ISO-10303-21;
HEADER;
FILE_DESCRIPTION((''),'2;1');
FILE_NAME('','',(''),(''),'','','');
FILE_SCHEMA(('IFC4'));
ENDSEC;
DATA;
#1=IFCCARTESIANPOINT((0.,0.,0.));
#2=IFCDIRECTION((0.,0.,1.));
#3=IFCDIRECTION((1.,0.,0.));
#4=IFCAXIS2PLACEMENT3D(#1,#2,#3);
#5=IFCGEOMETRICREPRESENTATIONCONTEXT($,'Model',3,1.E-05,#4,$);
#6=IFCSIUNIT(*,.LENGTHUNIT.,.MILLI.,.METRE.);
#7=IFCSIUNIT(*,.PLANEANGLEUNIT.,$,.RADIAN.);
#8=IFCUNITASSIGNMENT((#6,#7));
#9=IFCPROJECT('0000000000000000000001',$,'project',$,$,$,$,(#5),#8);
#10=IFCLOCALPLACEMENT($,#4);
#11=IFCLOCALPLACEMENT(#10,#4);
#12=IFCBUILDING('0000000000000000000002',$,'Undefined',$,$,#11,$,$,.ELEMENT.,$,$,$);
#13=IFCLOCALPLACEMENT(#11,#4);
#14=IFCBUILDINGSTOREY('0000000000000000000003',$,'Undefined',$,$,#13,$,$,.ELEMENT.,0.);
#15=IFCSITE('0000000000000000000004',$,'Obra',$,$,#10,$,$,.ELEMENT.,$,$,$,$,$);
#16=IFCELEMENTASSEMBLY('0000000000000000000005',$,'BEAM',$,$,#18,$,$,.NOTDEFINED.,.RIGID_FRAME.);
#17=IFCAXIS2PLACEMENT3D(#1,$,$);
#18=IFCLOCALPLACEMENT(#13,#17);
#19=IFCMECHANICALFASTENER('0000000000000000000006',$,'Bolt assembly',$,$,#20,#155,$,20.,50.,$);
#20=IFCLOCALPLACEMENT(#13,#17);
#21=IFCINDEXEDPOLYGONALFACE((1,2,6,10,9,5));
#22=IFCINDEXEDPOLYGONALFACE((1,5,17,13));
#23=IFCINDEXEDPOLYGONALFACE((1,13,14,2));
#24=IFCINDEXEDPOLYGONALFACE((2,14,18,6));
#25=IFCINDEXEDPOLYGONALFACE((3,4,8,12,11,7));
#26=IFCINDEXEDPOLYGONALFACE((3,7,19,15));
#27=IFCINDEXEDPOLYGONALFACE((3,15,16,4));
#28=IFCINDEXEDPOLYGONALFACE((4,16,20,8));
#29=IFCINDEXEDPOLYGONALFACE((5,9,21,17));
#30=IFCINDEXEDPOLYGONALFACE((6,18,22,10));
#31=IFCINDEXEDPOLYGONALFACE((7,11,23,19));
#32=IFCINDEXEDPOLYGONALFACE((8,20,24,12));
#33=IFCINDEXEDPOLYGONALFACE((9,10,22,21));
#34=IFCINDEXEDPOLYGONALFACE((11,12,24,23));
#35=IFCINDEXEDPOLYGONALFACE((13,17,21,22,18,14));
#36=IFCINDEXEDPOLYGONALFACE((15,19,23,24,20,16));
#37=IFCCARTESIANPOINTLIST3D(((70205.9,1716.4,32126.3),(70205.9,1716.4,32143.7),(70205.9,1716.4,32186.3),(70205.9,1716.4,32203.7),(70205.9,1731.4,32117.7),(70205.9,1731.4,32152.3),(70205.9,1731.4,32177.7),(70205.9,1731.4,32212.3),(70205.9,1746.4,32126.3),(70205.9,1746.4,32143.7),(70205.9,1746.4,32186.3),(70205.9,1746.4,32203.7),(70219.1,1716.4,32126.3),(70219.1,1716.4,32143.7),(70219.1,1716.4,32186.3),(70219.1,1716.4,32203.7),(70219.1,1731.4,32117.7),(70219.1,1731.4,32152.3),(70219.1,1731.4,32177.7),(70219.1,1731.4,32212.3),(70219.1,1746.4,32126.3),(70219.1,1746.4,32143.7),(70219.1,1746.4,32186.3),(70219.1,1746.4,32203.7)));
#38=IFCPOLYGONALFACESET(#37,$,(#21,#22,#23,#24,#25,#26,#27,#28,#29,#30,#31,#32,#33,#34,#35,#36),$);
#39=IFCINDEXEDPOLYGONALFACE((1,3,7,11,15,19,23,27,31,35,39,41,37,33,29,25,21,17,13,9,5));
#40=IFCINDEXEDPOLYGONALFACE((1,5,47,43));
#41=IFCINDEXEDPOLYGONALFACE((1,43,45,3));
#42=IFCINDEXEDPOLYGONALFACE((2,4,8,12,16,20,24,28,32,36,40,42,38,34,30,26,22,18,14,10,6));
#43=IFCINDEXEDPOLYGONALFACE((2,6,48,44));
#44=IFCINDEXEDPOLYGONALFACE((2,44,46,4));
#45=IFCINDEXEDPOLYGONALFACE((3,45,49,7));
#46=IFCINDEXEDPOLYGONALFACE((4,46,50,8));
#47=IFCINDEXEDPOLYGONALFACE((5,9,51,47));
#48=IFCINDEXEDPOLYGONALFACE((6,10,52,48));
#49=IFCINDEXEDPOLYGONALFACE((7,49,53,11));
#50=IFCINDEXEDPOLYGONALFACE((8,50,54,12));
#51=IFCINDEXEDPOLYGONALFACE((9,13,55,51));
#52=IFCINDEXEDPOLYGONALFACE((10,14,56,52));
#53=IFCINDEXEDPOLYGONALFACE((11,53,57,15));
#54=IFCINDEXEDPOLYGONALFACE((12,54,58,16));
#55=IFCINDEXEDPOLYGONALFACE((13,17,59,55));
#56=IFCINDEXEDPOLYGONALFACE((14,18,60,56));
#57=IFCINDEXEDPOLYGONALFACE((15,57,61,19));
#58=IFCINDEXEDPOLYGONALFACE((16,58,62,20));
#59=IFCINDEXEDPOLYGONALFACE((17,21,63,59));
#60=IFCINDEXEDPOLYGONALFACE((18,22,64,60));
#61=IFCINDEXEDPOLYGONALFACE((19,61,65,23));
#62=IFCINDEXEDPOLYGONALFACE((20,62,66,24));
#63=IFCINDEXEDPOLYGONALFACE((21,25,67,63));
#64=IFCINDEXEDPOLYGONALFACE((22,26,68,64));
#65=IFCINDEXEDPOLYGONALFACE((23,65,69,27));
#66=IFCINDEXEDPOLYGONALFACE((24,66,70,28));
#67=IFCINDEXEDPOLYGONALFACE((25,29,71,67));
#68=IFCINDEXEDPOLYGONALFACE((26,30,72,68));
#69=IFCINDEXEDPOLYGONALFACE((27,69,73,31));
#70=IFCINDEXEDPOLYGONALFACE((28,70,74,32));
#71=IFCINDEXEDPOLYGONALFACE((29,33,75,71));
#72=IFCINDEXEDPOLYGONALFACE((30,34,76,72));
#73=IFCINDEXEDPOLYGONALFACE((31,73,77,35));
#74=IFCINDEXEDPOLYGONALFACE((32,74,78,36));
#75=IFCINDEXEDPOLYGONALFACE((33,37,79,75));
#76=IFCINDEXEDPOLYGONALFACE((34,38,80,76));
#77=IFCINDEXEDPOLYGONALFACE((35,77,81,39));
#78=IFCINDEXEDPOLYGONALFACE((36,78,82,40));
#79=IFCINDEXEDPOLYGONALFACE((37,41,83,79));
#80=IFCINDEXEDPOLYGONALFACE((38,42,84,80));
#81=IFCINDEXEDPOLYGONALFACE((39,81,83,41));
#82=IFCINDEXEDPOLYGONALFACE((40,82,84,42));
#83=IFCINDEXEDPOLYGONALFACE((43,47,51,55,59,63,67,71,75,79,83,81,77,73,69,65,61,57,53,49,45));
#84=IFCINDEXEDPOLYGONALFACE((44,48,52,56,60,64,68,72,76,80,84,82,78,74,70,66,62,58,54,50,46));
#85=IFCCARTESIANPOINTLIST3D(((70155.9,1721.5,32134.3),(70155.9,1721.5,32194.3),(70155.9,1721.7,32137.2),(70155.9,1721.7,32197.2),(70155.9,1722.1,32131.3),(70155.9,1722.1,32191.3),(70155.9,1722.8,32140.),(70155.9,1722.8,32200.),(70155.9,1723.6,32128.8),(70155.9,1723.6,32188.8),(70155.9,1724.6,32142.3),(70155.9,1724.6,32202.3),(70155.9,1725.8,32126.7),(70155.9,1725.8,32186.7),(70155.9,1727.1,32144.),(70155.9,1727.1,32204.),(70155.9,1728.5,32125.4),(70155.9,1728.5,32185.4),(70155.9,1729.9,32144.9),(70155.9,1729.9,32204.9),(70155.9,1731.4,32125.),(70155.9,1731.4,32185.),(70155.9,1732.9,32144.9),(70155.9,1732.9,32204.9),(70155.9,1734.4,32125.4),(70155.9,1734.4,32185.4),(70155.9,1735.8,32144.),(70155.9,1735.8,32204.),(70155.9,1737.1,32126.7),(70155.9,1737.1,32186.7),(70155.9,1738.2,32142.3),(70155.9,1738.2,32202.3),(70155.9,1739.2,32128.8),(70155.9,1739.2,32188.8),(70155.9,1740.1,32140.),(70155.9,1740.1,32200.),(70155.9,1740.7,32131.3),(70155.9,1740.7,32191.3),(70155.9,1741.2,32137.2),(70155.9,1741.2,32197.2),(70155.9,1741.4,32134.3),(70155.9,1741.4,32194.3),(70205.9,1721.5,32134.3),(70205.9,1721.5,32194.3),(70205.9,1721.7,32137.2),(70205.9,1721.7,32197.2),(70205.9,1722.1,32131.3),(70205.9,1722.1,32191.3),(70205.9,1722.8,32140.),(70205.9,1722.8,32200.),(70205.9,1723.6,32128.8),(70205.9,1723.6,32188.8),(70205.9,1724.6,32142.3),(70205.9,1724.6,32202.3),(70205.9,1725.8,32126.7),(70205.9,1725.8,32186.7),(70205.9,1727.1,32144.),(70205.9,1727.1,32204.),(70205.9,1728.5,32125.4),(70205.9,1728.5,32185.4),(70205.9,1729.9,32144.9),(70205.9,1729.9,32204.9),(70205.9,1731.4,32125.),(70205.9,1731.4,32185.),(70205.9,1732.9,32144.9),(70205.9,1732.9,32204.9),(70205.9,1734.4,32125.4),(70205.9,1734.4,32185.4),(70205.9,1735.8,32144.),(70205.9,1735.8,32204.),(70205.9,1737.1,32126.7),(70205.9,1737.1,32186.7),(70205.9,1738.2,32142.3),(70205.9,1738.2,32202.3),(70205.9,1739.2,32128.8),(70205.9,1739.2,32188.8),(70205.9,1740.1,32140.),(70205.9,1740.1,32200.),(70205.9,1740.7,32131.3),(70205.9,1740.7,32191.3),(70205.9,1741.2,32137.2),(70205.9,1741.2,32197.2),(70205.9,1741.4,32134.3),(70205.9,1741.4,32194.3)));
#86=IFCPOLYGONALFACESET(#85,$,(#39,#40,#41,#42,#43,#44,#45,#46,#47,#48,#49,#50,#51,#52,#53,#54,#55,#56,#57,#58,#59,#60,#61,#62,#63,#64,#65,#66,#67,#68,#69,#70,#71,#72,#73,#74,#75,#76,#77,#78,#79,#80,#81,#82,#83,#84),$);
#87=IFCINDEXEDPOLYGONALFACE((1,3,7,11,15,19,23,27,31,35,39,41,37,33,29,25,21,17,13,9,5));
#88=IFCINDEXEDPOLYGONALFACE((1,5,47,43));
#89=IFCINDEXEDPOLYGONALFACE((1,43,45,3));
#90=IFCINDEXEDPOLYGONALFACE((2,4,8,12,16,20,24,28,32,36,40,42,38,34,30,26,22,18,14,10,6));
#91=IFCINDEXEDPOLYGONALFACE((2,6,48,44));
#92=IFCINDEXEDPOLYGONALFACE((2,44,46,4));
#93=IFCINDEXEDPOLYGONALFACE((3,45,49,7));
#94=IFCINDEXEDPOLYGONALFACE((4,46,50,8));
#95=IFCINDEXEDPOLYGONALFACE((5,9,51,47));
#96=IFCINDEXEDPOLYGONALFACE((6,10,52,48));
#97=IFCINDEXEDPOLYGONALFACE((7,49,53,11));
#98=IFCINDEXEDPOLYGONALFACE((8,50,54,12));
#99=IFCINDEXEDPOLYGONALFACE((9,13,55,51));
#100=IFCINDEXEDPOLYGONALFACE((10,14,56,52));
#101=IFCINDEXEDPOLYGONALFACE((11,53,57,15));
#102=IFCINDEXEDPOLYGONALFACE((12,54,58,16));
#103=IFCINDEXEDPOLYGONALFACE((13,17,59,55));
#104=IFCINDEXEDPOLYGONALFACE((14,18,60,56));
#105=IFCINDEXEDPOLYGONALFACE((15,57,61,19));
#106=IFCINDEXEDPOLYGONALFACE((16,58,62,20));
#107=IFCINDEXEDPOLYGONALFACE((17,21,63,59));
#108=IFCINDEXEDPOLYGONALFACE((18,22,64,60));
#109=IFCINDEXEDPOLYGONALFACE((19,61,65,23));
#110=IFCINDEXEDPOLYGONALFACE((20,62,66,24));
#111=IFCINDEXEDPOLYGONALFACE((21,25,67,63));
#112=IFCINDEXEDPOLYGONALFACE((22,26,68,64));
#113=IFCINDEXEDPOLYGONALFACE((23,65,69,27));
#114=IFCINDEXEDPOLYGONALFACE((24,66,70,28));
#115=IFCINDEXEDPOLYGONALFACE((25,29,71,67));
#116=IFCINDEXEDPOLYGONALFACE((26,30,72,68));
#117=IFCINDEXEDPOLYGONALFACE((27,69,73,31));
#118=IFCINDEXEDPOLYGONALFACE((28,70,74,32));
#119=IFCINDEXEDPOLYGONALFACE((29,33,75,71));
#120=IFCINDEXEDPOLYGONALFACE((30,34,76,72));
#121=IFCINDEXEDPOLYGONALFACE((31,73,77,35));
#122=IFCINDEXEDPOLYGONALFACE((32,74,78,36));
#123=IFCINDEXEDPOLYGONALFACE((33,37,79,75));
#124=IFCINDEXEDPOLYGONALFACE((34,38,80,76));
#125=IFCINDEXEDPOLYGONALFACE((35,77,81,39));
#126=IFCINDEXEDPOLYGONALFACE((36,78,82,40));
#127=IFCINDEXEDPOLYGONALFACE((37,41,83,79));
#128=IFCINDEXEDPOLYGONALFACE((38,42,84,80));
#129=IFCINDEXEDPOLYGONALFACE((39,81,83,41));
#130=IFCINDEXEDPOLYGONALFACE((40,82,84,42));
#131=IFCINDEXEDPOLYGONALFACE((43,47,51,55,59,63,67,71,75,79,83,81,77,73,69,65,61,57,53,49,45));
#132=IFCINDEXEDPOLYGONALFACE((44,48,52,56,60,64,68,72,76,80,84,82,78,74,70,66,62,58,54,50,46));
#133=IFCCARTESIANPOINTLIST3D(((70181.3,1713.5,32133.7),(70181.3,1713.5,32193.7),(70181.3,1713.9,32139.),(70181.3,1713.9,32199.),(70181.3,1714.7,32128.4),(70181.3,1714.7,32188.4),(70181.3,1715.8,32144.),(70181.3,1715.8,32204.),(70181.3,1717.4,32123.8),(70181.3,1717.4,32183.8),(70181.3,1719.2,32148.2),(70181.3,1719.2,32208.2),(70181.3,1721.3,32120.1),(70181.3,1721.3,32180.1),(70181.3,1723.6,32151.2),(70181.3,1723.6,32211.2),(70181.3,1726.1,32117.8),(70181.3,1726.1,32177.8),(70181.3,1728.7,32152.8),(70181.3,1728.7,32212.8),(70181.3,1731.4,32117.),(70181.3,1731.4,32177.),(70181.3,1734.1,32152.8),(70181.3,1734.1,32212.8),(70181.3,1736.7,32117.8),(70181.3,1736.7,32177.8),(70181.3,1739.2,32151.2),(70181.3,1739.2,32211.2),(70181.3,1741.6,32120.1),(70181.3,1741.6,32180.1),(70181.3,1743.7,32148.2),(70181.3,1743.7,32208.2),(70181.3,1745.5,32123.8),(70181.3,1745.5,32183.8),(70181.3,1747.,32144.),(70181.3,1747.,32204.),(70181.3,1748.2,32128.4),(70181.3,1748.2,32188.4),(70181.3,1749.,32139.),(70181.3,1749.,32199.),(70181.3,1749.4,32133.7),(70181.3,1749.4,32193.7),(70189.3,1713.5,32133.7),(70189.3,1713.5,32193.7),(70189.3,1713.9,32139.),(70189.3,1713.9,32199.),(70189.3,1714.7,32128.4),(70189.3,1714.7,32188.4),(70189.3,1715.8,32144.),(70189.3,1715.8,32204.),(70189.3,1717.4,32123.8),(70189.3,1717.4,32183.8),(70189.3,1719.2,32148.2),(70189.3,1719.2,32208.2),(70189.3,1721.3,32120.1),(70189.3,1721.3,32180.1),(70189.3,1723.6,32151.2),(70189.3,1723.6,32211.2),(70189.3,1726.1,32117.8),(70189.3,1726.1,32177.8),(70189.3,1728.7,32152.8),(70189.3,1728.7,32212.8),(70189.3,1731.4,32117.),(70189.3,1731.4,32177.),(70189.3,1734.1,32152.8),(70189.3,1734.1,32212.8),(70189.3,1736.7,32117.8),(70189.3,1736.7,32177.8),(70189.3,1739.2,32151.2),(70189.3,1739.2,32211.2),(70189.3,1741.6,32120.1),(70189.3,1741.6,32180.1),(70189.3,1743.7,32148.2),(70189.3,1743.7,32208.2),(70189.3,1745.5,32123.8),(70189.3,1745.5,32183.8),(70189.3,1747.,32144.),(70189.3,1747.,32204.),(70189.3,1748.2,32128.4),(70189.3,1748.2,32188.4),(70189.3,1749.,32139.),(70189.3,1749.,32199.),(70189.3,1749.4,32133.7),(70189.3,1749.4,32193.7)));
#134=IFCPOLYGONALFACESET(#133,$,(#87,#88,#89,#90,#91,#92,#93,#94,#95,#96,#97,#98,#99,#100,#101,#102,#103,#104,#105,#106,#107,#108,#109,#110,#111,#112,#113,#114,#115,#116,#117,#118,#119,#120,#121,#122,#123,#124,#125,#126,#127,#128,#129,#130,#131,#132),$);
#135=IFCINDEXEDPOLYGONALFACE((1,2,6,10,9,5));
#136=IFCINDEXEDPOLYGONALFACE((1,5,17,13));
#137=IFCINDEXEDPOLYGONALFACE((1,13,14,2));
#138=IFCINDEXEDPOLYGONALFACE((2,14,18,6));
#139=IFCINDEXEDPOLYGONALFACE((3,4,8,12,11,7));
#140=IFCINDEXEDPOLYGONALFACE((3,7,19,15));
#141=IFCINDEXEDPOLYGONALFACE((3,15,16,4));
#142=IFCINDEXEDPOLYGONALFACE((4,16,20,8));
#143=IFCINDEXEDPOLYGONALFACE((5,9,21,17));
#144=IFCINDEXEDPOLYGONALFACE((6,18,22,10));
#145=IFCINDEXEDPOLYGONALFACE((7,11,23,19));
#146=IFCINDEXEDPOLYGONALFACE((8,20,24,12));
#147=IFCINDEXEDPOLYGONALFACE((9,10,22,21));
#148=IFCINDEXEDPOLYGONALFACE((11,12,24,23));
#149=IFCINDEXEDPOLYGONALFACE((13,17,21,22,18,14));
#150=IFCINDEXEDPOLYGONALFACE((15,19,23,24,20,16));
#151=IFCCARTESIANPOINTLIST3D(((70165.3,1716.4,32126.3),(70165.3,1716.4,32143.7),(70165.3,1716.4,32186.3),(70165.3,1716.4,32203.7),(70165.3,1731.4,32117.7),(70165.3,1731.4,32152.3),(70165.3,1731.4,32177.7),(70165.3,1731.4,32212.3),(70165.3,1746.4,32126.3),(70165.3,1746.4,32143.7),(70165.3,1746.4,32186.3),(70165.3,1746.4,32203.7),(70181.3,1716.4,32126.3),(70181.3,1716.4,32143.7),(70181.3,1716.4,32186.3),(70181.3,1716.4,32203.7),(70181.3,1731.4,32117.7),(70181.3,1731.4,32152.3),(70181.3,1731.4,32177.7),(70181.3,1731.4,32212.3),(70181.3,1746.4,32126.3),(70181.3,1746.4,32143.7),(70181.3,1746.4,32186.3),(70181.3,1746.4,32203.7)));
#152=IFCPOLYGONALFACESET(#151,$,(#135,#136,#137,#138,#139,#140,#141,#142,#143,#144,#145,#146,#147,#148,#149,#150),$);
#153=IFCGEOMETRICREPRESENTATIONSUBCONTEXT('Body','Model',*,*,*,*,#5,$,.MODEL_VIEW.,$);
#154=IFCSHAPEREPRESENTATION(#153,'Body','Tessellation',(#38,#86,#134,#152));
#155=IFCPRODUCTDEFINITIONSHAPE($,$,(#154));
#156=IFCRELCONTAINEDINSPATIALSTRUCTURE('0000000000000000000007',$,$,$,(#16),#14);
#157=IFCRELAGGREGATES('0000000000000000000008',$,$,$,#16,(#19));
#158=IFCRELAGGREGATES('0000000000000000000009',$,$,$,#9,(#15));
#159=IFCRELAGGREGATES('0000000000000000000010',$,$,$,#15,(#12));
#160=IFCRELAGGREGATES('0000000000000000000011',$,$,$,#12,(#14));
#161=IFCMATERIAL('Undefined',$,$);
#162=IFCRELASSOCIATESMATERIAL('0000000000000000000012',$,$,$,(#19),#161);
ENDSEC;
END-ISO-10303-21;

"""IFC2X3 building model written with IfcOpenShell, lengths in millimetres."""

from ifc_helpers import new_model, si_unit, frame, origin_with_axes, origin_2d_with_axis, place, context, subcontext, project, spatial, polyline, circle, outline, extrude, source, transform, mapped, material, element, aggregate, save


model = new_model("IFC2X3")

# Units and contexts
model_context = context("Model", 3, precision=1e-05, world=origin_with_axes())
body_context = subcontext(model_context, "Body", "Model", "MODEL_VIEW")
ifc_project = project(units=[si_unit("LENGTHUNIT", "METRE", prefix="MILLI"), si_unit("PLANEANGLEUNIT", "RADIAN")], contexts=[model_context])

# Site, building, storey
site_placement = place(None, origin_with_axes())
site = spatial("IfcSite", under=ifc_project, at=site_placement, Name="Obra", CompositionType="ELEMENT")
building_placement = place(site_placement, origin_with_axes())
building = spatial("IfcBuilding", under=site, at=building_placement, Name="Undefined", CompositionType="ELEMENT")
storey_placement = place(building_placement, origin_with_axes())
storey = spatial("IfcBuildingStorey", under=building, at=storey_placement, Name="Undefined", CompositionType="ELEMENT", Elevation=0.0)

# Shared definitions
ifc_material_1 = material(Name="Undefined")

# Element assembly, mechanical fastener
assembly_1_placement = place(storey_placement, origin_with_axes())
assembly_1 = element("IfcElementAssembly", 1, at=assembly_1_placement, inside=storey, Name="BEAM", AssemblyPlace="NOTDEFINED", PredefinedType="RIGID_FRAME")
shared_shape_1 = source(origin_with_axes(), body_context, "Body", "SweptSolid", [
    extrude(outline(polyline([(17.3, 0.0), (8.7, 15.0), (-8.7, 15.0), (-17.3, 0.0), (-8.7, -15.0), (8.7, -15.0), (17.3, 0.0)])), frame((0.0, -26.5, 0.0), z_axis=(0.0, 1.0, 0.0), x_axis=(1.0, 0.0, 0.0)), (0.0, 0.0, 1.0), 13.2),
    extrude(circle(Radius=10.0, at=origin_2d_with_axis()), frame((0.0, -13.3, 0.0), z_axis=(0.0, 1.0, 0.0), x_axis=(1.0, 0.0, 0.0)), (0.0, 0.0, 1.0), 50.0),
    extrude(circle(Radius=18.0, at=origin_2d_with_axis()), frame((0.0, 3.3, 0.0), z_axis=(0.0, 1.0, 0.0), x_axis=(1.0, 0.0, 0.0)), (0.0, 0.0, 1.0), 8.0),
    extrude(outline(polyline([(17.3, 0.0), (8.7, 15.0), (-8.7, 15.0), (-17.3, 0.0), (-8.7, -15.0), (8.7, -15.0), (17.3, 0.0)])), frame((0.0, 11.3, 0.0), z_axis=(0.0, 1.0, 0.0), x_axis=(1.0, 0.0, 0.0)), (0.0, 0.0, 1.0), 16.0),
])
mechanical_fastener_1_placement = place(assembly_1_placement, frame((70192.6, 1691.4, 32235.0), z_axis=(-0.000014, 1.0, 0.0), x_axis=(0.0, 0.0, -1.0)))
mechanical_fastener_1 = element("IfcMechanicalFastener", 2, at=mechanical_fastener_1_placement, material=ifc_material_1, Name="Bolt assembly", NominalDiameter=20.0, NominalLength=50.0, context=body_context, shape_type="MappedRepresentation", body=[
    mapped(shared_shape_1, transform((40.0, 0.0, 40.0))),
    mapped(shared_shape_1, transform((100.0, 0.0, 40.0))),
])
aggregate(assembly_1, [mechanical_fastener_1])

save(model, "model.ifc")
